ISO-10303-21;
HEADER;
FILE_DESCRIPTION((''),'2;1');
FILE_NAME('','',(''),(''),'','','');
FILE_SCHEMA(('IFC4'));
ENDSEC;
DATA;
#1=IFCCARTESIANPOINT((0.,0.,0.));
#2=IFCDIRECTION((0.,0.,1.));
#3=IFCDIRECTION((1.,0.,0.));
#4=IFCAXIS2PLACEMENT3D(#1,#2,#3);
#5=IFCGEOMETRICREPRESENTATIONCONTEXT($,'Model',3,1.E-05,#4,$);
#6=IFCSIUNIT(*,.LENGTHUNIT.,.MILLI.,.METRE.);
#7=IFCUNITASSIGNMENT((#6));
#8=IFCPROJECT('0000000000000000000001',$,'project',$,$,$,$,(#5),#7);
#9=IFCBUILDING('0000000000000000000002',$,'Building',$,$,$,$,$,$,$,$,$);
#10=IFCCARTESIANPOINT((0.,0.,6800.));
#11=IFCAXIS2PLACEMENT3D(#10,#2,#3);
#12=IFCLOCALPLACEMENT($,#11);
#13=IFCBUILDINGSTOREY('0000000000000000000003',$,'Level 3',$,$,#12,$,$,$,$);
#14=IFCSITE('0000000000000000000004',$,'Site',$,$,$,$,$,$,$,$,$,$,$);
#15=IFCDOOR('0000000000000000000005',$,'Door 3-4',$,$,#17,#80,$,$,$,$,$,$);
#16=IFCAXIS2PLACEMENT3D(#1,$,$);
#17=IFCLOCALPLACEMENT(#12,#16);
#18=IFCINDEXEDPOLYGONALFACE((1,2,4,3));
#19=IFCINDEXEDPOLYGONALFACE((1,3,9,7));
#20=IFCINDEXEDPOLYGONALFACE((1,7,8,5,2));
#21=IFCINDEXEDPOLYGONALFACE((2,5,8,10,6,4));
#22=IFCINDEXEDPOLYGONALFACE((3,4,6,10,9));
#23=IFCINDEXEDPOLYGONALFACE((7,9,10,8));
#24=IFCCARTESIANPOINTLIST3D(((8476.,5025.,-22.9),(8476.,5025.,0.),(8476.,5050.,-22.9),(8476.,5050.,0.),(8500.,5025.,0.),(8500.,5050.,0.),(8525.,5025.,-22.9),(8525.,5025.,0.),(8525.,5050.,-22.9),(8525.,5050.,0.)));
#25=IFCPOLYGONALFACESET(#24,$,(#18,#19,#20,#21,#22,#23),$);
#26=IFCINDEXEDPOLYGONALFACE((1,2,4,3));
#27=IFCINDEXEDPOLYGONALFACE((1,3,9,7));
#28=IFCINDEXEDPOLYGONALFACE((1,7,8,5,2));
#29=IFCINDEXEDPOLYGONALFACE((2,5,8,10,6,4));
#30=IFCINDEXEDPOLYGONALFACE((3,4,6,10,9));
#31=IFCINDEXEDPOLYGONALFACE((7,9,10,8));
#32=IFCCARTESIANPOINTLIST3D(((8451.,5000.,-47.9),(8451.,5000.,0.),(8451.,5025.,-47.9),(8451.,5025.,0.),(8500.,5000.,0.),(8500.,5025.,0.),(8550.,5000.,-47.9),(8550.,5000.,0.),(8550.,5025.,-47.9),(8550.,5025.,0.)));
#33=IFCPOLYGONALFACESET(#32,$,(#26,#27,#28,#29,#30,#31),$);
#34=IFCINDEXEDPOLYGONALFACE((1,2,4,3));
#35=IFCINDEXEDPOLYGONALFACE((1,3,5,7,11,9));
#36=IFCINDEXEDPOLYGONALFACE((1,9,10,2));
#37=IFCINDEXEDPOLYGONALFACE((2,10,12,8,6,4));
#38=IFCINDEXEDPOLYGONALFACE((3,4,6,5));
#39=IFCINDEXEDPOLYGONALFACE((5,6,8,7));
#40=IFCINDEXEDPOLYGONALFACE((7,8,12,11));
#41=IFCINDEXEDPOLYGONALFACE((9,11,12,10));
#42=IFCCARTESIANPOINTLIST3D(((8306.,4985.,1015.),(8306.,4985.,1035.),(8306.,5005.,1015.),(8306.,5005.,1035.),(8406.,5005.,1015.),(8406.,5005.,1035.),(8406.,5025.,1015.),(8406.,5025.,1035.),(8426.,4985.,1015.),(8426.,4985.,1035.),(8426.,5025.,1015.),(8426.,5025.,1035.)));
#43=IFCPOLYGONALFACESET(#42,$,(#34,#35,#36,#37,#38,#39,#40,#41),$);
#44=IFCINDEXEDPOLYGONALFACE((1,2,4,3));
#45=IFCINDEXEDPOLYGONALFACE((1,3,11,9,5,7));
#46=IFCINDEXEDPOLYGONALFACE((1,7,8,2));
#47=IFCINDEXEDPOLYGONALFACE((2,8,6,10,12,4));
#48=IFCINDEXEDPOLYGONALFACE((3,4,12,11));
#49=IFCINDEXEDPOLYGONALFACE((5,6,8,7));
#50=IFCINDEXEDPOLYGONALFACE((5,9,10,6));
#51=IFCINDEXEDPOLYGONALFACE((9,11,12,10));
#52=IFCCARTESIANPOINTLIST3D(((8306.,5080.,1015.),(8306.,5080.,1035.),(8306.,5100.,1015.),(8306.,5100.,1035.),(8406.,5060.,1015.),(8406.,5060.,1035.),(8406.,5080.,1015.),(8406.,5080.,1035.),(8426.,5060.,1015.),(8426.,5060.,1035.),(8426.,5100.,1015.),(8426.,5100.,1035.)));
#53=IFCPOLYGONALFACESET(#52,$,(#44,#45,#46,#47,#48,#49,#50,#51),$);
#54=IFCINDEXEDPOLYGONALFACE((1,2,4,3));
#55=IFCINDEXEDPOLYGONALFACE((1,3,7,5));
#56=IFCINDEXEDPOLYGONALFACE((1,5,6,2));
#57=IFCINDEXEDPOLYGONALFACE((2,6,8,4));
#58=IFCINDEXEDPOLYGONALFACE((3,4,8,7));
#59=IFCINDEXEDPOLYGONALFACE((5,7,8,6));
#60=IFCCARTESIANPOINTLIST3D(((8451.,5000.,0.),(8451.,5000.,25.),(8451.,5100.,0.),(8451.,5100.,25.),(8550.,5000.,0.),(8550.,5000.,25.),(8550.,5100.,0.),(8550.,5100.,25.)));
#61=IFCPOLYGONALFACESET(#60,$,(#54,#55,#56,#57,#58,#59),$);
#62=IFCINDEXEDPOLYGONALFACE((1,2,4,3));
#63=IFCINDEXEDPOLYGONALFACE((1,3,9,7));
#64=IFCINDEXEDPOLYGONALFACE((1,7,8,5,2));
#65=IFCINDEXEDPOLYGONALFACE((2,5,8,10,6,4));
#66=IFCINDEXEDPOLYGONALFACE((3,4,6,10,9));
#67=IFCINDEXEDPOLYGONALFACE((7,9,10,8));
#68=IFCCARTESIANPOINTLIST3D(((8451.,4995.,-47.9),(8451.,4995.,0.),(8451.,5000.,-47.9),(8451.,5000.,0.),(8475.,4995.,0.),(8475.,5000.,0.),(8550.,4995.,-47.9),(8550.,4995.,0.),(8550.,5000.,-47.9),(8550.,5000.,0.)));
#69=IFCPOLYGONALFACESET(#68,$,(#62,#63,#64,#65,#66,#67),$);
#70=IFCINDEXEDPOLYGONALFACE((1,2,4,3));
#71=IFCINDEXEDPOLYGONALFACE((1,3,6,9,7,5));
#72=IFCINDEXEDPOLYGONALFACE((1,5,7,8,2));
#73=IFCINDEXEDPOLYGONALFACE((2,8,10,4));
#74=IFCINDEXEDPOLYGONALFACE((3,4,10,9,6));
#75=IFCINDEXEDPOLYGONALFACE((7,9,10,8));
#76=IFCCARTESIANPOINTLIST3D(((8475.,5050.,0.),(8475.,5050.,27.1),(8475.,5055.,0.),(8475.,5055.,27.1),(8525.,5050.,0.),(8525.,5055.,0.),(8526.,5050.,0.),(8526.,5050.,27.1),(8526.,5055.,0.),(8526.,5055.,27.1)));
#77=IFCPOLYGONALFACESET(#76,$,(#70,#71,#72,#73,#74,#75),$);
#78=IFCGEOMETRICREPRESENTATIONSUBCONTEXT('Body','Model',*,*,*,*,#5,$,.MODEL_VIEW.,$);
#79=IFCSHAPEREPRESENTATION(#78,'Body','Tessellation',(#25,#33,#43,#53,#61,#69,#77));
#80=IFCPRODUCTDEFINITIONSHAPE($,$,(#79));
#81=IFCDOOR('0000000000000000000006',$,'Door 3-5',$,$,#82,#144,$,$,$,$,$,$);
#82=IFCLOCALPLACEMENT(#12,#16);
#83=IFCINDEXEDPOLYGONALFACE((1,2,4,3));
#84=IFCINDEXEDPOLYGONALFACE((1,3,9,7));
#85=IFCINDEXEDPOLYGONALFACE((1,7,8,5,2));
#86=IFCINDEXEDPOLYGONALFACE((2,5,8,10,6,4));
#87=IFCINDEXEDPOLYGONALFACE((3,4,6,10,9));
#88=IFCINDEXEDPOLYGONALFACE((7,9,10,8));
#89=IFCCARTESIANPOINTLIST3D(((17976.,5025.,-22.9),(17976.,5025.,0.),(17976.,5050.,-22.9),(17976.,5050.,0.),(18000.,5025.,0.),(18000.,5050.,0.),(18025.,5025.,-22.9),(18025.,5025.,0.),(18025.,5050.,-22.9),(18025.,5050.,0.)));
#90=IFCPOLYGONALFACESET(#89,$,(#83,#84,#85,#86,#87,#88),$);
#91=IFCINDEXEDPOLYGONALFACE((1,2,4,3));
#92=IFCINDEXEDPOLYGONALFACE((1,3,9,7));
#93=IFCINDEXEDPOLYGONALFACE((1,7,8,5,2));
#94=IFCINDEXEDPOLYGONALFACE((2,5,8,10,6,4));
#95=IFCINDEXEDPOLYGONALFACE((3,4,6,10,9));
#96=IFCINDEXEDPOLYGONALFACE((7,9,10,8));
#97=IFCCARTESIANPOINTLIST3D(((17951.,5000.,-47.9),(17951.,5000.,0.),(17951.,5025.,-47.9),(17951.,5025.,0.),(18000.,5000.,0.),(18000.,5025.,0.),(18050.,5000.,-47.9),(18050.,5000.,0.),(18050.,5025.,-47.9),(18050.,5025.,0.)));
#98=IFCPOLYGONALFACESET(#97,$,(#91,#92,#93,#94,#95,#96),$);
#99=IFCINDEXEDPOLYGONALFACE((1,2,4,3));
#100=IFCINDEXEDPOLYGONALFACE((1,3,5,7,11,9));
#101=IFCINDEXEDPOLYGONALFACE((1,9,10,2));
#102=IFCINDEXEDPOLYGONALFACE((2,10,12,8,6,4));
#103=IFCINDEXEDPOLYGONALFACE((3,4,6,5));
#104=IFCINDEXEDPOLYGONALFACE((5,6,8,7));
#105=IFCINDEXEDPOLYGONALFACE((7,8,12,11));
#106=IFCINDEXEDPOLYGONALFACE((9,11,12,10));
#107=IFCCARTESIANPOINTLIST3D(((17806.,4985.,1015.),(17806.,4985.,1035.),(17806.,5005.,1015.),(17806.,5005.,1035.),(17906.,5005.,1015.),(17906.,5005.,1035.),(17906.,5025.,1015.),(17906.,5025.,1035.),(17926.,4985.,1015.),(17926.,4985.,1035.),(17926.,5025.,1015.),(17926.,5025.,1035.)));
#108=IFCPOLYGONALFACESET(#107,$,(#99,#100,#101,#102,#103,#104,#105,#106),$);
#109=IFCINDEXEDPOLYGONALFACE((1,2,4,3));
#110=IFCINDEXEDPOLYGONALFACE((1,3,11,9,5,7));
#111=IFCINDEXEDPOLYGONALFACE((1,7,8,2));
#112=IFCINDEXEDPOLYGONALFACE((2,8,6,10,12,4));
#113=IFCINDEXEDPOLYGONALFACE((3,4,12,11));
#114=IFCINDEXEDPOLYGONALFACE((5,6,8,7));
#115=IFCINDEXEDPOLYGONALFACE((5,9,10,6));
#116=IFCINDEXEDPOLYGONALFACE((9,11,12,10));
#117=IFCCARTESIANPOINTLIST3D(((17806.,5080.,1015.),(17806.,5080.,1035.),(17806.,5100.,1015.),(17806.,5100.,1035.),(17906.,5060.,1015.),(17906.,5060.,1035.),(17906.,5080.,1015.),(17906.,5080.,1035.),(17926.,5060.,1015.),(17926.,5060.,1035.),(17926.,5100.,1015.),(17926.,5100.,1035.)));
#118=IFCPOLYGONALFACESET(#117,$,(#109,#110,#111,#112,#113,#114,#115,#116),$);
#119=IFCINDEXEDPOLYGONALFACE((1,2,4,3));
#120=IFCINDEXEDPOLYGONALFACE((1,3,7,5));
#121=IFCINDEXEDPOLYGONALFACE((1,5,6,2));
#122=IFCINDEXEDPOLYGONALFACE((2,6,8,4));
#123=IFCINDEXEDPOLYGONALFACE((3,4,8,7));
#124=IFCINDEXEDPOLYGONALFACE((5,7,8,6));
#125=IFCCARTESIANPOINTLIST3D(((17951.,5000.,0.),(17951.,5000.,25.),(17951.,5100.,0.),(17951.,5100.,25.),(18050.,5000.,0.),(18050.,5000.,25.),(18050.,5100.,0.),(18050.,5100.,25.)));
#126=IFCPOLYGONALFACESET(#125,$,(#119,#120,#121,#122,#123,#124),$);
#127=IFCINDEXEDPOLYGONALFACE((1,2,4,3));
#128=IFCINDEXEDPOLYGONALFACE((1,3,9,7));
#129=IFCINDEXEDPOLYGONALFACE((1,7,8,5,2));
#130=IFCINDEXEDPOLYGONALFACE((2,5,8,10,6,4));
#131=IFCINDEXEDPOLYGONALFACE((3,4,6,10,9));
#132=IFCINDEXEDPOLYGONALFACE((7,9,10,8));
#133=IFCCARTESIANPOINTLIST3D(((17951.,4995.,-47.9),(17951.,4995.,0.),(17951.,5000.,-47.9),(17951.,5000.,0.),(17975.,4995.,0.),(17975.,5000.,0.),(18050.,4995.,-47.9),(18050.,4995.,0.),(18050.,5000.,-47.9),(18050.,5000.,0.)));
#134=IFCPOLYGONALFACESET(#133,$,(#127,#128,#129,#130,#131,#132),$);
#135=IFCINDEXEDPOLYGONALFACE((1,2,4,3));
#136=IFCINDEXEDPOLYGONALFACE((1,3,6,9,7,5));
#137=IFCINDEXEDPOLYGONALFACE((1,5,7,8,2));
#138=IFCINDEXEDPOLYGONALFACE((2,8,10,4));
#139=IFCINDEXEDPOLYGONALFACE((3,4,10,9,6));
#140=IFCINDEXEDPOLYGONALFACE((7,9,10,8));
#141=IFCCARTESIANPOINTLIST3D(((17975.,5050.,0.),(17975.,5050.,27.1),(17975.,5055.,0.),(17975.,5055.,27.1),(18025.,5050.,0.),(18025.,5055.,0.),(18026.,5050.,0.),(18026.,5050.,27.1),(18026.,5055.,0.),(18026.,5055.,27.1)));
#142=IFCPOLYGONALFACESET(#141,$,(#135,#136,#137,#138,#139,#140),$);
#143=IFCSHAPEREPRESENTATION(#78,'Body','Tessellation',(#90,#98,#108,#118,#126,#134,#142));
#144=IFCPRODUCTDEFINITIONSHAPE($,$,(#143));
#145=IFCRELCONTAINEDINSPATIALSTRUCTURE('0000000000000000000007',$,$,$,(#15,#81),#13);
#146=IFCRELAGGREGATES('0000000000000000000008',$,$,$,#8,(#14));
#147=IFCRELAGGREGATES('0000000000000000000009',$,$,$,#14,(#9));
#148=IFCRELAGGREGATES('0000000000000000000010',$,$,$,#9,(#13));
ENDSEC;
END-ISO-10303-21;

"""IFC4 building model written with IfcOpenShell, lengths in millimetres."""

from ifc_helpers import new_model, si_unit, frame, origin_with_axes, place, context, subcontext, project, spatial, line, indexed_curve, outline, extrude, element, save


model = new_model("IFC4")

# Units and contexts
model_context = context("Model", 3, precision=1e-05, world=origin_with_axes())
body_context = subcontext(model_context, "Body", "Model", "MODEL_VIEW")
ifc_project = project(units=[si_unit("LENGTHUNIT", "METRE", prefix="MILLI")], contexts=[model_context])

# Site, building, storey
site = spatial("IfcSite", under=ifc_project, Name="Site")
building = spatial("IfcBuilding", under=site, Name="Building")
storey_placement = place(None, frame((0.0, 0.0, 6800.0), z_axis=(0.0, 0.0, 1.0), x_axis=(1.0, 0.0, 0.0)))
storey = spatial("IfcBuildingStorey", under=building, at=storey_placement, Name="Level 3")

# Doors
door_1_placement = place(storey_placement, frame((8500.0, 5000.0, 0.0), z_axis=(0.0, 0.0, 1.0), x_axis=(1.0, 0.0, 0.0)))
element("IfcDoor", 1, at=door_1_placement, inside=storey, Name="Door 3-4", context=body_context, shape_type="SweptSolid", body=[
    extrude(outline(indexed_curve([(0.0, 0.0), (0.0, 2.1), (1.0, 2.1), (1.0, 0.0), (-24.0, 0.0), (-24.0, -22.9), (25.0, -22.9), (25.0, 0.0)], segments=[line(1, 2, 3, 4, 5, 6, 7, 8, 1)])), frame((0.0, 25.0, 0.0), z_axis=(0.0, -1.0, 0.0), x_axis=(1.0, 0.0, 0.0)), (0.0, 0.0, -1.0), 25.0),
    extrude(outline(indexed_curve([(0.0, 0.0), (0.0, 2.1), (1.0, 2.1), (1.0, 0.0), (-49.0, 0.0), (-49.0, -47.9), (50.0, -47.9), (50.0, 0.0)], segments=[line(1, 2, 3, 4, 5, 6, 7, 8, 1)])), frame((0.0, 0.0, 0.0), z_axis=(0.0, -1.0, 0.0), x_axis=(1.0, 0.0, 0.0)), (0.0, 0.0, -1.0), 25.0),
    extrude(outline(indexed_curve([(0.0, 0.0), (-49.0, 0.0), (-49.0, 35.0), (0.0, 35.0)], segments=[line(1, 2, 3, 4, 1)])), frame((25.0, 25.0, 25.0), z_axis=(0.0, 0.0, 1.0), x_axis=(1.0, 0.0, 0.0)), (0.0, 0.0, 1.0), -47.9),
    extrude(outline(indexed_curve([(0.0, 0.0), (0.0, -40.0), (-120.0, -40.0), (-120.0, -20.0), (-20.0, -20.0), (-20.0, 0.0)], segments=[line(1, 2, 3, 4, 5, 6, 1)])), frame((-74.0, 25.0, 1015.0), z_axis=(0.0, 0.0, 1.0), x_axis=(1.0, 0.0, 0.0)), (0.0, 0.0, 1.0), 20.0),
    extrude(outline(indexed_curve([(0.0, 0.0), (0.0, 40.0), (-120.0, 40.0), (-120.0, 20.0), (-20.0, 20.0), (-20.0, 0.0)], segments=[line(1, 2, 3, 4, 5, 6, 1)])), frame((-74.0, 60.0, 1015.0), z_axis=(0.0, 0.0, 1.0), x_axis=(1.0, 0.0, 0.0)), (0.0, 0.0, 1.0), 20.0),
    extrude(outline(indexed_curve([(0.0, 0.0), (-99.0, 0.0), (-99.0, 100.0), (0.0, 100.0)], segments=[line(1, 2, 3, 4, 1)])), frame((50.0, 0.0, 0.0), z_axis=(0.0, 0.0, 1.0), x_axis=(1.0, 0.0, 0.0)), (0.0, 0.0, 1.0), 25.0),
    extrude(outline(indexed_curve([(0.0, 0.0), (0.0, 27.1), (51.0, 27.1), (51.0, 0.0), (-24.0, 0.0), (-24.0, -47.9), (75.0, -47.9), (75.0, 0.0)], segments=[line(1, 2, 3, 4, 5, 6, 7, 8, 1)])), frame((-25.0, -5.0, 0.0), z_axis=(0.0, -1.0, 0.0), x_axis=(1.0, 0.0, 0.0)), (0.0, 0.0, -1.0), 5.0),
    extrude(outline(indexed_curve([(0.0, 0.0), (0.0, 27.1), (51.0, 27.1), (51.0, 0.0), (1.0, 0.0), (1.0, -22.9), (50.0, -22.9), (50.0, 0.0)], segments=[line(1, 2, 3, 4, 5, 6, 7, 8, 1)])), frame((-25.0, 50.0, 0.0), z_axis=(0.0, -1.0, 0.0), x_axis=(1.0, 0.0, 0.0)), (0.0, 0.0, -1.0), 5.0),
])
door_2_placement = place(storey_placement, frame((18000.0, 5000.0, 0.0), z_axis=(0.0, 0.0, 1.0), x_axis=(1.0, 0.0, 0.0)))
element("IfcDoor", 2, at=door_2_placement, inside=storey, Name="Door 3-5", context=body_context, shape_type="SweptSolid", body=[
    extrude(outline(indexed_curve([(0.0, 0.0), (0.0, 2.1), (1.0, 2.1), (1.0, 0.0), (-24.0, 0.0), (-24.0, -22.9), (25.0, -22.9), (25.0, 0.0)], segments=[line(1, 2, 3, 4, 5, 6, 7, 8, 1)])), frame((0.0, 25.0, 0.0), z_axis=(0.0, -1.0, 0.0), x_axis=(1.0, 0.0, 0.0)), (0.0, 0.0, -1.0), 25.0),
    extrude(outline(indexed_curve([(0.0, 0.0), (0.0, 2.1), (1.0, 2.1), (1.0, 0.0), (-49.0, 0.0), (-49.0, -47.9), (50.0, -47.9), (50.0, 0.0)], segments=[line(1, 2, 3, 4, 5, 6, 7, 8, 1)])), frame((0.0, 0.0, 0.0), z_axis=(0.0, -1.0, 0.0), x_axis=(1.0, 0.0, 0.0)), (0.0, 0.0, -1.0), 25.0),
    extrude(outline(indexed_curve([(0.0, 0.0), (-49.0, 0.0), (-49.0, 35.0), (0.0, 35.0)], segments=[line(1, 2, 3, 4, 1)])), frame((25.0, 25.0, 25.0), z_axis=(0.0, 0.0, 1.0), x_axis=(1.0, 0.0, 0.0)), (0.0, 0.0, 1.0), -47.9),
    extrude(outline(indexed_curve([(0.0, 0.0), (0.0, -40.0), (-120.0, -40.0), (-120.0, -20.0), (-20.0, -20.0), (-20.0, 0.0)], segments=[line(1, 2, 3, 4, 5, 6, 1)])), frame((-74.0, 25.0, 1015.0), z_axis=(0.0, 0.0, 1.0), x_axis=(1.0, 0.0, 0.0)), (0.0, 0.0, 1.0), 20.0),
    extrude(outline(indexed_curve([(0.0, 0.0), (0.0, 40.0), (-120.0, 40.0), (-120.0, 20.0), (-20.0, 20.0), (-20.0, 0.0)], segments=[line(1, 2, 3, 4, 5, 6, 1)])), frame((-74.0, 60.0, 1015.0), z_axis=(0.0, 0.0, 1.0), x_axis=(1.0, 0.0, 0.0)), (0.0, 0.0, 1.0), 20.0),
    extrude(outline(indexed_curve([(0.0, 0.0), (-99.0, 0.0), (-99.0, 100.0), (0.0, 100.0)], segments=[line(1, 2, 3, 4, 1)])), frame((50.0, 0.0, 0.0), z_axis=(0.0, 0.0, 1.0), x_axis=(1.0, 0.0, 0.0)), (0.0, 0.0, 1.0), 25.0),
    extrude(outline(indexed_curve([(0.0, 0.0), (0.0, 27.1), (51.0, 27.1), (51.0, 0.0), (-24.0, 0.0), (-24.0, -47.9), (75.0, -47.9), (75.0, 0.0)], segments=[line(1, 2, 3, 4, 5, 6, 7, 8, 1)])), frame((-25.0, -5.0, 0.0), z_axis=(0.0, -1.0, 0.0), x_axis=(1.0, 0.0, 0.0)), (0.0, 0.0, -1.0), 5.0),
    extrude(outline(indexed_curve([(0.0, 0.0), (0.0, 27.1), (51.0, 27.1), (51.0, 0.0), (1.0, 0.0), (1.0, -22.9), (50.0, -22.9), (50.0, 0.0)], segments=[line(1, 2, 3, 4, 5, 6, 7, 8, 1)])), frame((-25.0, 50.0, 0.0), z_axis=(0.0, -1.0, 0.0), x_axis=(1.0, 0.0, 0.0)), (0.0, 0.0, -1.0), 5.0),
])

save(model, "model.ifc")
